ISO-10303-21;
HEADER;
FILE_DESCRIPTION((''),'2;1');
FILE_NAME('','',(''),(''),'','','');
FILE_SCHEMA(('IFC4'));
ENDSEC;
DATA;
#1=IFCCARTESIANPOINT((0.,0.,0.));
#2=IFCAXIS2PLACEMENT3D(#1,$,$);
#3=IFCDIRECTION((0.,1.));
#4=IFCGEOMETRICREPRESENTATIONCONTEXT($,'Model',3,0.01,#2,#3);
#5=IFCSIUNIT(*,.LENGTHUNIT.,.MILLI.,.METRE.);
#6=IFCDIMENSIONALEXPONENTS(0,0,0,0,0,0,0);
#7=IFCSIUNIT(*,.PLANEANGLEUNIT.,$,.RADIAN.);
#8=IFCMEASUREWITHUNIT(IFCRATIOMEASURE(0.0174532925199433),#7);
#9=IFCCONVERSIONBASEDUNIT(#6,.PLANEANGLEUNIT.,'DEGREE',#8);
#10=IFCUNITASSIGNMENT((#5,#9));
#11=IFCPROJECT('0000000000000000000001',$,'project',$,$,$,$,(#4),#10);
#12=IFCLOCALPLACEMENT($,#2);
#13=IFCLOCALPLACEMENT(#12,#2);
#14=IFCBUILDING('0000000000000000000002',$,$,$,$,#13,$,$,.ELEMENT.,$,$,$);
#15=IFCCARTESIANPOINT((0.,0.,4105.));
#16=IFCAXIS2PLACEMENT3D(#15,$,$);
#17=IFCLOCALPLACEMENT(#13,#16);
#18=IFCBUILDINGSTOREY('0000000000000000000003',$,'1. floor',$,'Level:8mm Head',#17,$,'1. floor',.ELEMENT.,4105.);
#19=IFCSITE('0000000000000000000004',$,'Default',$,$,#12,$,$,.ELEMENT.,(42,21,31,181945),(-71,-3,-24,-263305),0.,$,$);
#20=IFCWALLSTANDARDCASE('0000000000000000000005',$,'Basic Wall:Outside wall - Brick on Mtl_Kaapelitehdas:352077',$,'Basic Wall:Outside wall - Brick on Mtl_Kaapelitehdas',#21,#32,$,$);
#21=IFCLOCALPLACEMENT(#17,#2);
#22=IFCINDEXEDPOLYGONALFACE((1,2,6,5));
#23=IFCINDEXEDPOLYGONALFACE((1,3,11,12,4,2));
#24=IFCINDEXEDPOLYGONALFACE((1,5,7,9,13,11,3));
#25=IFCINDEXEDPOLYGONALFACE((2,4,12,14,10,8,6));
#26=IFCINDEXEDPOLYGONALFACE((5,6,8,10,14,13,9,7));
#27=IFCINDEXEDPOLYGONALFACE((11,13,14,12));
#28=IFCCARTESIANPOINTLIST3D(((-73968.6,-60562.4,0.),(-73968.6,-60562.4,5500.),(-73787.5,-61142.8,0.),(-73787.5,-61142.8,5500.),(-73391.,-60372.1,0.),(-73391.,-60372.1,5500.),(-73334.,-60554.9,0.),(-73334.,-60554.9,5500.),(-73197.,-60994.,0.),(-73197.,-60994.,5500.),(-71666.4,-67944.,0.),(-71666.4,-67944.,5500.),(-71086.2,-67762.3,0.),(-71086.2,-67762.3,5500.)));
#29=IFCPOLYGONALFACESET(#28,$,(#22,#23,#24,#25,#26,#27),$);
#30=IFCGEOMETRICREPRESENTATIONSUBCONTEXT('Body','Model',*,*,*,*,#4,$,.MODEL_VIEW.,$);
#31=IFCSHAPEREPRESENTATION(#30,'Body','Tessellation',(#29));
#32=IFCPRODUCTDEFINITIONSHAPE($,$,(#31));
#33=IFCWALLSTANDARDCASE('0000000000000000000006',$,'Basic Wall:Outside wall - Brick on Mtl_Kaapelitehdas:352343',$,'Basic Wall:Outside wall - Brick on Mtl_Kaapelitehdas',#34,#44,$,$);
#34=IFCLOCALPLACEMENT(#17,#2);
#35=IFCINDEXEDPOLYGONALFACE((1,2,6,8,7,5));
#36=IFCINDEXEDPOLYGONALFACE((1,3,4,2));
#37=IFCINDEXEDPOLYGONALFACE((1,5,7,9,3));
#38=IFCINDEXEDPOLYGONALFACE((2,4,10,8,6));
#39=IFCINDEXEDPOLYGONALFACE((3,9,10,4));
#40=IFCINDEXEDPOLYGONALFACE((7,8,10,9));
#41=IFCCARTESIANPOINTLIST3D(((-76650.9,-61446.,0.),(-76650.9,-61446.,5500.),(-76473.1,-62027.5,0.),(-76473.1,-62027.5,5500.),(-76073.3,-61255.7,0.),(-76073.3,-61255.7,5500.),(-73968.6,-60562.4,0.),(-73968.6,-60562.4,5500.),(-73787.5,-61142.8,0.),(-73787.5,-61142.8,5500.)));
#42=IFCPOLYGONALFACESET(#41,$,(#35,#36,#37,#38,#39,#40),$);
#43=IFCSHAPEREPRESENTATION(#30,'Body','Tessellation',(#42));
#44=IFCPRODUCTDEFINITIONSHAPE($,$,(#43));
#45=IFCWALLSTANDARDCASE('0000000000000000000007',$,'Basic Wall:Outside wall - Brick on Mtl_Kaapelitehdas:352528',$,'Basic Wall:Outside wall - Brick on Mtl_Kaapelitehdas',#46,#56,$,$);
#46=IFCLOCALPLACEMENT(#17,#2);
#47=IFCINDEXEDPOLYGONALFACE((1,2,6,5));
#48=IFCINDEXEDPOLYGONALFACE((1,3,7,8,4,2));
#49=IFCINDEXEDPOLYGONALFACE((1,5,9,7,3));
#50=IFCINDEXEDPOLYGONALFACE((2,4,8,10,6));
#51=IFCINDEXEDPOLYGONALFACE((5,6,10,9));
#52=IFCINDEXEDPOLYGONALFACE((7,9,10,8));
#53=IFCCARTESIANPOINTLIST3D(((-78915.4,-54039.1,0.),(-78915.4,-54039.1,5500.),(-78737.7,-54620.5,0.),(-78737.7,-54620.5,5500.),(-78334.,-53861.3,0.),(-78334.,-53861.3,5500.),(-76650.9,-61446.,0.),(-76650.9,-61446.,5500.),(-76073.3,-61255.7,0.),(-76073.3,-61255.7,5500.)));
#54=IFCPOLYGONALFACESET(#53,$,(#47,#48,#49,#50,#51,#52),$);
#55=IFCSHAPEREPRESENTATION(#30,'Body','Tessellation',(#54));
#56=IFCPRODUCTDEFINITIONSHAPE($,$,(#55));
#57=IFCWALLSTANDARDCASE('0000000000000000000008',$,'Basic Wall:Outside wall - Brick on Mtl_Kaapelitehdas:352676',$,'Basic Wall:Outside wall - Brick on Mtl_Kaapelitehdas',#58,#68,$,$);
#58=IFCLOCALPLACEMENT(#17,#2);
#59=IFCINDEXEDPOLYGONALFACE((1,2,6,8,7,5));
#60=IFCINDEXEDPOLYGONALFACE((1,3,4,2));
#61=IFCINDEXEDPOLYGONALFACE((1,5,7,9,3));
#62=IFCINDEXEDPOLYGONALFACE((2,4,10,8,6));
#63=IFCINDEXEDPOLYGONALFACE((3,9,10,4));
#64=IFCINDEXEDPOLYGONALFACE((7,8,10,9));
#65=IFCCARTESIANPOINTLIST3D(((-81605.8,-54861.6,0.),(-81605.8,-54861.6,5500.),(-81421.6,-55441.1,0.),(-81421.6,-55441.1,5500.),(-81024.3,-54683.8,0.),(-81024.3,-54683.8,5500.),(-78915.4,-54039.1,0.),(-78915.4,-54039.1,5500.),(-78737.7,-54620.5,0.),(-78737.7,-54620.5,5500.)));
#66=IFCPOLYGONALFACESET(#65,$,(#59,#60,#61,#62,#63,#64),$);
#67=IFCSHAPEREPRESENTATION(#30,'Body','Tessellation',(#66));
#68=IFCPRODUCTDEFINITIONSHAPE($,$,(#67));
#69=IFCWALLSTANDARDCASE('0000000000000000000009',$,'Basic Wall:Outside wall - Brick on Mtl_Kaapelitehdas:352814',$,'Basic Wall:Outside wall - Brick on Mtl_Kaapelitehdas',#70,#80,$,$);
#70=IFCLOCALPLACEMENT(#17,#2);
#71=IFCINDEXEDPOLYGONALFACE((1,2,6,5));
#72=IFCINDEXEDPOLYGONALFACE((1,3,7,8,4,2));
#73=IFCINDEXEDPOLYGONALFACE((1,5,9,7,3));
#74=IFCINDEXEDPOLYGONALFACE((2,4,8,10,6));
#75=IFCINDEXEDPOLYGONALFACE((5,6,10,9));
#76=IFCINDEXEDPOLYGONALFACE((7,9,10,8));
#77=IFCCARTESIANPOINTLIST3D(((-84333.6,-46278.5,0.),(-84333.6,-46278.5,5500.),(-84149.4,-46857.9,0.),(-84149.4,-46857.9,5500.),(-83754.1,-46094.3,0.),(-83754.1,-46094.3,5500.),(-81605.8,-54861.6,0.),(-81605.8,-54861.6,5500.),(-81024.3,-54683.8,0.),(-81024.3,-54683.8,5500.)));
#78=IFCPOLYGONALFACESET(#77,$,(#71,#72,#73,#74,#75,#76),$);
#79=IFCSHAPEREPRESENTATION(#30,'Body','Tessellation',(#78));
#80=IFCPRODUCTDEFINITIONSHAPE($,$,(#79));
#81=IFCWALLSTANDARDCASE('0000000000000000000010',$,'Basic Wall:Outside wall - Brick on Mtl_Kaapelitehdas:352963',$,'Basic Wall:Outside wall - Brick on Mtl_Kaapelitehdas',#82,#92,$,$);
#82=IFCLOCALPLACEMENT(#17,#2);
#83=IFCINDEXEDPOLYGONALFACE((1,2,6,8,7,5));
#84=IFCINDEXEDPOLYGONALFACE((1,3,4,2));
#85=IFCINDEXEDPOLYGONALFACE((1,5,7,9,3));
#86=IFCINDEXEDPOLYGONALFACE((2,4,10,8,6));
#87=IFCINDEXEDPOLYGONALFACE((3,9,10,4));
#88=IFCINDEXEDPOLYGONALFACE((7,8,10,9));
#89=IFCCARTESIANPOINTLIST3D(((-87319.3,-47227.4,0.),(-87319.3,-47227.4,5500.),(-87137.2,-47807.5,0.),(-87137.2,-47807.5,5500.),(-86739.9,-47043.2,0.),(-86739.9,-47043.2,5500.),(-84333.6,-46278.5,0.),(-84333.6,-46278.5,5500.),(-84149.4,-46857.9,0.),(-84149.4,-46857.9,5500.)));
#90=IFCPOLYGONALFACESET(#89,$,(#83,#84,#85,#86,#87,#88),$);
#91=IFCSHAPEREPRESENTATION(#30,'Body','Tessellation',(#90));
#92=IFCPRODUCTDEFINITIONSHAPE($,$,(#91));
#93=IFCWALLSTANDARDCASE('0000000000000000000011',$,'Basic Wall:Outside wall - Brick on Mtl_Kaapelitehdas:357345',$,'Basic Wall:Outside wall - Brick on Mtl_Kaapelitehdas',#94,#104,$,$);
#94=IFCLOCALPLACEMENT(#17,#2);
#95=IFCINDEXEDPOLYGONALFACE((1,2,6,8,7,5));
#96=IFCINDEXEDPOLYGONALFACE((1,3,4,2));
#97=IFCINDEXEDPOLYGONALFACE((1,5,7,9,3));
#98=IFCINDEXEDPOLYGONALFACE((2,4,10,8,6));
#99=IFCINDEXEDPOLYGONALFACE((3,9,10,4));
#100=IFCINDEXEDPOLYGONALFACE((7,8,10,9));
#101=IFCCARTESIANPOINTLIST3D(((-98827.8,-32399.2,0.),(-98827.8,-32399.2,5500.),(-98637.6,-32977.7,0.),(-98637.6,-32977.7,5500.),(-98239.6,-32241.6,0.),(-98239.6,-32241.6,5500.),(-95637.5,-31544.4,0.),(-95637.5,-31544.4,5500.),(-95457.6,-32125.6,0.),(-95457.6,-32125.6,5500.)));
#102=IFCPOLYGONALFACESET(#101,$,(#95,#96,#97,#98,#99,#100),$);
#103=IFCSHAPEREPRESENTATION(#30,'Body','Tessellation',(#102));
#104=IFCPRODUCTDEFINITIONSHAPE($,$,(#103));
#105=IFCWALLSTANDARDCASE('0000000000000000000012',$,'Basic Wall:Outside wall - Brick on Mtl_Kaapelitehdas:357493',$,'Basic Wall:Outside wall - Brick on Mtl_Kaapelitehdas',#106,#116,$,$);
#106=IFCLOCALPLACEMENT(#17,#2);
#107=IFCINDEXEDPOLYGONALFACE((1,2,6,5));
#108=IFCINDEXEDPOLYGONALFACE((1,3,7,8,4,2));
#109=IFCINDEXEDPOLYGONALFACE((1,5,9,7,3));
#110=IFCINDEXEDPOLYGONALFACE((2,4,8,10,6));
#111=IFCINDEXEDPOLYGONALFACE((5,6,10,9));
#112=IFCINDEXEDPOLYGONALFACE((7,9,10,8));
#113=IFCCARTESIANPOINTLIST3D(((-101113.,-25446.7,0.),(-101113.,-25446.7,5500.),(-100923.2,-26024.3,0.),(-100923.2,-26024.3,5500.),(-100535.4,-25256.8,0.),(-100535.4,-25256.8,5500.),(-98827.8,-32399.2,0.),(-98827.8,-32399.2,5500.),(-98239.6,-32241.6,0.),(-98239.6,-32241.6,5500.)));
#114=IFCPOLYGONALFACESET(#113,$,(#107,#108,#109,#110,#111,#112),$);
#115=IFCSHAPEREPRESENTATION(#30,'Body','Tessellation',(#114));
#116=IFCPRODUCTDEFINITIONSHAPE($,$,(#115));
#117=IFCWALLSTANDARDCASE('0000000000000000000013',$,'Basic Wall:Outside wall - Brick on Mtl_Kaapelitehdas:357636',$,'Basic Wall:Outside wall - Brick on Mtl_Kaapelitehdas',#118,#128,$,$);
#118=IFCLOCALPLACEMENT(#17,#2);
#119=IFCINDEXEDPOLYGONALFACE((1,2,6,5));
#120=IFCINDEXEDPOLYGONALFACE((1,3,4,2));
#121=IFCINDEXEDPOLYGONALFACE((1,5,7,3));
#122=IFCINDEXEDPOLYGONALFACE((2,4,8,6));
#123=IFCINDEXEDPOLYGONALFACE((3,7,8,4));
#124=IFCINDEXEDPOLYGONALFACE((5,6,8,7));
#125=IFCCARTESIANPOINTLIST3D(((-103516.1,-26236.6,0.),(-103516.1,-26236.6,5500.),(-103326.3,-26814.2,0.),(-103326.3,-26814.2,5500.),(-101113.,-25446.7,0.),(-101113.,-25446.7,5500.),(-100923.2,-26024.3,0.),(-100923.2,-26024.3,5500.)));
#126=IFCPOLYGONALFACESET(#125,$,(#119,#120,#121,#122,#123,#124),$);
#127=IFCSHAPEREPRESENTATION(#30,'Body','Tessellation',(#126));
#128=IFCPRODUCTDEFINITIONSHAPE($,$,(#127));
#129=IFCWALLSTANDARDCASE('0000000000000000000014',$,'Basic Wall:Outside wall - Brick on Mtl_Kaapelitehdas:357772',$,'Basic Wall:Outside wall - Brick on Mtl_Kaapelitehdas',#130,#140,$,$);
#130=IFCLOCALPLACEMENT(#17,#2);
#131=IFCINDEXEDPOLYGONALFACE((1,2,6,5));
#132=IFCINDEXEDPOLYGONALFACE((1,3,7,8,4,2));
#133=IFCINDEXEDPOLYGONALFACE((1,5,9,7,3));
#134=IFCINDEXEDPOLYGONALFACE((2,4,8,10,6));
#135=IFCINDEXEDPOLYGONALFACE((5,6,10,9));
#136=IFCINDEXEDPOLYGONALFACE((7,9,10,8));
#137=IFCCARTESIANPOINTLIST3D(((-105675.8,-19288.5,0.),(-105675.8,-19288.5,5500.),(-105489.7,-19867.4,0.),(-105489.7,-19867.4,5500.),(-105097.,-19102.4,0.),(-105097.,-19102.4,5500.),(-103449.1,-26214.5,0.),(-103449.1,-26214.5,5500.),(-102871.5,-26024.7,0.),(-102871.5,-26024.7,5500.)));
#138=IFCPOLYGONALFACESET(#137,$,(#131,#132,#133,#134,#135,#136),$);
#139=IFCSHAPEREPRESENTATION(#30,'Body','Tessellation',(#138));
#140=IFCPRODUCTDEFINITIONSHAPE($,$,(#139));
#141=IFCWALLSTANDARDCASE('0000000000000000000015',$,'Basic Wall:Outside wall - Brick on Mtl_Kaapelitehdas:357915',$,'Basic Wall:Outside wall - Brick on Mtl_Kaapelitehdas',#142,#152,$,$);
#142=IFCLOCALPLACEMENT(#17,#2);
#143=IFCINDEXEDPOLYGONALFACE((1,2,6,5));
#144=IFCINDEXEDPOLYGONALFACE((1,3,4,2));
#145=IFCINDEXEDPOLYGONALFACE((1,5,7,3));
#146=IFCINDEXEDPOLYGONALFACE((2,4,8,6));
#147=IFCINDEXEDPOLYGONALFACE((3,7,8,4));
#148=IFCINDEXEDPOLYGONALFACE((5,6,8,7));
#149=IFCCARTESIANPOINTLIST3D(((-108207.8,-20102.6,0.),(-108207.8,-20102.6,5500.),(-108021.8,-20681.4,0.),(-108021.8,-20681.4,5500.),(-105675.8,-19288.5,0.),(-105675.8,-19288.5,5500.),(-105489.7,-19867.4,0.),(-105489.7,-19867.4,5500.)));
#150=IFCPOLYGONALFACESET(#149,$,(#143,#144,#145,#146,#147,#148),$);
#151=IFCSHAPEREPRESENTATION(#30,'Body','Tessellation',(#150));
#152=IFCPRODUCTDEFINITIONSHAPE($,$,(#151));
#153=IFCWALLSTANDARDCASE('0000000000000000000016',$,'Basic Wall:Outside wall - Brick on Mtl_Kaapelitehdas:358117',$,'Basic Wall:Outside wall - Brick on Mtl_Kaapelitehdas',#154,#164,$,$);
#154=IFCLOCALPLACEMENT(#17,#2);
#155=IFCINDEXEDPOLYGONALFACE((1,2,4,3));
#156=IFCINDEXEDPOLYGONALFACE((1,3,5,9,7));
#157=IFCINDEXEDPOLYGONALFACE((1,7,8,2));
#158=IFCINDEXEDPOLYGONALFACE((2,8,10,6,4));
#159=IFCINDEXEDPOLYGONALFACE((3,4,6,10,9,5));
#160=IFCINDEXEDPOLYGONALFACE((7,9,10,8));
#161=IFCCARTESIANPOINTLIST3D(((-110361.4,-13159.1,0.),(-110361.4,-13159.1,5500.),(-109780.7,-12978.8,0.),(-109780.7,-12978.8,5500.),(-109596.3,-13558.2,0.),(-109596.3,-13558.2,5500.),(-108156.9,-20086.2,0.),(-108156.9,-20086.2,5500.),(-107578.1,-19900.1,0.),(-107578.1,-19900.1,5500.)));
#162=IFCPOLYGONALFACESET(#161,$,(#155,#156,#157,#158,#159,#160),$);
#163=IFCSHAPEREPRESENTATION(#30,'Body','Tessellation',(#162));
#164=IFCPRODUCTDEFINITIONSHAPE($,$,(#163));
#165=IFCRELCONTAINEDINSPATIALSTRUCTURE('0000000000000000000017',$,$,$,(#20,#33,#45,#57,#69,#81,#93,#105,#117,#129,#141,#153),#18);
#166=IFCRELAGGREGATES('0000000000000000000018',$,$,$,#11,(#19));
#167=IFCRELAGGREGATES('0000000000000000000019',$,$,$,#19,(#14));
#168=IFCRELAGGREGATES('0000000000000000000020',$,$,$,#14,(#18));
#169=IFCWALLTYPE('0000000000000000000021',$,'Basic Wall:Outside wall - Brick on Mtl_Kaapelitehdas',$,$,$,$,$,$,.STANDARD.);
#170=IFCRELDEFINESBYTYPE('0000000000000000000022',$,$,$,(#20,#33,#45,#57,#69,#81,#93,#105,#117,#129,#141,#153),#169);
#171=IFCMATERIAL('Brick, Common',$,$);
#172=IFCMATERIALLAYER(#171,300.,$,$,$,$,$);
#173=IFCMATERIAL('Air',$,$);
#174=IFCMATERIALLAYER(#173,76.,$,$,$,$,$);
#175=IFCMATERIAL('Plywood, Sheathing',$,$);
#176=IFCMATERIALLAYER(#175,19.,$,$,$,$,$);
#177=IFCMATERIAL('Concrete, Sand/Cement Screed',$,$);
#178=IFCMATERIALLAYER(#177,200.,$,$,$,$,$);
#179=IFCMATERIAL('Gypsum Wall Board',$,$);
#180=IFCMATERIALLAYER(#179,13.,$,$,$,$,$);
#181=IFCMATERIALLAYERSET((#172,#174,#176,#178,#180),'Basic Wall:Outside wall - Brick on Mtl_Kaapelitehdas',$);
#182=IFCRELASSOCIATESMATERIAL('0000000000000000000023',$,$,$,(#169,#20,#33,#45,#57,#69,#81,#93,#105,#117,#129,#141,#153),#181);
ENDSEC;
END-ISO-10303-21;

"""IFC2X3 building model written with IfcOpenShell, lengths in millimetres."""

from ifc_helpers import new_model, entity, si_unit, converted_unit, direction, frame, frame_2d, origin, place, context, subcontext, project, spatial, polyline, rectangle, outline, extrude, material, layer, layer_set, layer_usage, type_object, element, save


model = new_model("IFC2X3")

# Units and contexts
model_context = context("Model", 3, precision=0.01, world=origin(), true_north=direction((0.0, 1.0)))
body_context = subcontext(model_context, "Body", "Model", "MODEL_VIEW")
ifc_project = project(units=[si_unit("LENGTHUNIT", "METRE", prefix="MILLI"), converted_unit("PLANEANGLEUNIT", "DEGREE", entity("IfcRatioMeasure", 0.0174532925199433), si_unit("PLANEANGLEUNIT", "RADIAN"), dimensions=[0, 0, 0, 0, 0, 0, 0])], contexts=[model_context])

# Site, building, storey
site_placement = place(None, origin())
site = spatial("IfcSite", under=ifc_project, at=site_placement, Name="Default", CompositionType="ELEMENT", RefLatitude=(42, 21, 31, 181945), RefLongitude=(-71, -3, -24, -263305), RefElevation=0.0)
building_placement = place(site_placement, origin())
building = spatial("IfcBuilding", under=site, at=building_placement, CompositionType="ELEMENT")
storey_placement = place(building_placement, frame((0.0, 0.0, 4105.0)))
storey = spatial("IfcBuildingStorey", under=building, at=storey_placement, Name="1. floor", ObjectType="Level:8mm Head", LongName="1. floor", CompositionType="ELEMENT", Elevation=4105.0)

# Walls
ifc_material_1 = material(Name="Brick, Common")
ifc_layer_1 = layer(ifc_material_1, 300.0)
ifc_material_2 = material(Name="Air")
ifc_layer_2 = layer(ifc_material_2, 76.0)
ifc_material_3 = material(Name="Plywood, Sheathing")
ifc_layer_3 = layer(ifc_material_3, 19.0)
ifc_material_4 = material(Name="Concrete, Sand/Cement Screed")
ifc_layer_4 = layer(ifc_material_4, 200.0)
ifc_material_5 = material(Name="Gypsum Wall Board")
ifc_layer_5 = layer(ifc_material_5, 13.0)
ifc_layer_set_1 = layer_set([ifc_layer_1, ifc_layer_2, ifc_layer_3, ifc_layer_4, ifc_layer_5], Name="Basic Wall:Outside wall - Brick on Mtl_Kaapelitehdas")
ifc_layer_usage_1 = layer_usage(ifc_layer_set_1, "AXIS2", "NEGATIVE", 304.0)
wall_type_1 = type_object("IfcWallType", Name="Basic Wall:Outside wall - Brick on Mtl_Kaapelitehdas", PredefinedType="STANDARD", material=ifc_layer_set_1)
wall_1_placement = place(storey_placement, frame((-71376.1, -67853.5, 0.0), z_axis=(0.0, 0.0, 1.0), x_axis=(-0.297735, 0.954648, 0.0)))
element("IfcWallStandardCase", 1, at=wall_1_placement, inside=storey, type_object=wall_type_1, material=ifc_layer_usage_1, Name="Basic Wall:Outside wall - Brick on Mtl_Kaapelitehdas:352077", ObjectType="Basic Wall:Outside wall - Brick on Mtl_Kaapelitehdas", context=body_context, shape_type="SweptSolid", body=[
    extrude(outline(polyline([(7742.0, -304.0), (7732.3, 304.0), (7124.3, 304.0), (0.0, 304.0), (0.8, -304.0), (7090.5, -304.0), (7550.5, -304.0), (7742.0, -304.0)])), origin(), (0.0, 0.0, 1.0), 5500.0),
])
ifc_layer_usage_2 = layer_usage(ifc_layer_set_1, "AXIS2", "NEGATIVE", 304.0)
wall_2_placement = place(storey_placement, frame((-73873.4, -60851.1, 0.0), z_axis=(0.0, 0.0, 1.0), x_axis=(-0.949794, -0.312877, 0.0)))
element("IfcWallStandardCase", 2, at=wall_2_placement, inside=storey, type_object=wall_type_1, material=ifc_layer_usage_2, Name="Basic Wall:Outside wall - Brick on Mtl_Kaapelitehdas:352343", ObjectType="Basic Wall:Outside wall - Brick on Mtl_Kaapelitehdas", context=body_context, shape_type="SweptSolid", body=[
    extrude(outline(polyline([(2824.1, -304.0), (2837.2, 304.0), (9.7, 304.0), (0.0, -304.0), (2216.0, -304.0), (2824.1, -304.0)])), origin(), (0.0, 0.0, 1.0), 5500.0),
])
ifc_layer_usage_3 = layer_usage(ifc_layer_set_1, "AXIS2", "NEGATIVE", 304.0)
wall_3_placement = place(storey_placement, frame((-76360.2, -61357.1, 0.0), z_axis=(0.0, 0.0, 1.0), x_axis=(-0.292372, 0.956305, 0.0)))
element("IfcWallStandardCase", 3, at=wall_3_placement, inside=storey, type_object=wall_type_1, material=ifc_layer_usage_3, Name="Basic Wall:Outside wall - Brick on Mtl_Kaapelitehdas:352528", ObjectType="Basic Wall:Outside wall - Brick on Mtl_Kaapelitehdas", context=body_context, shape_type="SweptSolid", body=[
    extrude(outline(polyline([(7745.3, -304.0), (7745.3, 304.0), (7137.3, 304.0), (0.0, 304.0), (13.1, -304.0), (7745.3, -304.0)])), origin(), (0.0, 0.0, 1.0), 5500.0),
])
ifc_layer_usage_4 = layer_usage(ifc_layer_set_1, "AXIS2", "NEGATIVE", 304.0)
wall_4_placement = place(storey_placement, frame((-78826.5, -54329.8, 0.0), z_axis=(0.0, 0.0, 1.0), x_axis=(-0.956305, -0.292372, 0.0)))
element("IfcWallStandardCase", 4, at=wall_4_placement, inside=storey, type_object=wall_type_1, material=ifc_layer_usage_4, Name="Basic Wall:Outside wall - Brick on Mtl_Kaapelitehdas:352676", ObjectType="Basic Wall:Outside wall - Brick on Mtl_Kaapelitehdas", context=body_context, shape_type="SweptSolid", body=[
    extrude(outline(polyline([(2813.3, -304.0), (2806.6, 304.0), (0.0, 304.0), (0.0, -304.0), (2205.2, -304.0), (2813.3, -304.0)])), origin(), (0.0, 0.0, 1.0), 5500.0),
])
ifc_layer_usage_5 = layer_usage(ifc_layer_set_1, "AXIS2", "NEGATIVE", 304.0)
wall_5_placement = place(storey_placement, frame((-81314.0, -54775.9, 0.0), z_axis=(0.0, 0.0, 1.0), x_axis=(-0.302882, 0.953028, 0.0)))
element("IfcWallStandardCase", 5, at=wall_5_placement, inside=storey, type_object=wall_type_1, material=ifc_layer_usage_5, Name="Basic Wall:Outside wall - Brick on Mtl_Kaapelitehdas:352814", ObjectType="Basic Wall:Outside wall - Brick on Mtl_Kaapelitehdas", context=body_context, shape_type="SweptSolid", body=[
    extrude(outline(polyline([(9012.8, -304.0), (9012.8, 304.0), (8404.8, 304.0), (6.7, 304.0), (0.0, -304.0), (9012.8, -304.0)])), origin(), (0.0, 0.0, 1.0), 5500.0),
])
ifc_layer_usage_6 = layer_usage(ifc_layer_set_1, "AXIS2", "NEGATIVE", 304.0)
wall_6_placement = place(storey_placement, frame((-84241.5, -46568.2, 0.0), z_axis=(0.0, 0.0, 1.0), x_axis=(-0.953028, -0.302882, 0.0)))
element("IfcWallStandardCase", 6, at=wall_6_placement, inside=storey, type_object=wall_type_1, material=ifc_layer_usage_6, Name="Basic Wall:Outside wall - Brick on Mtl_Kaapelitehdas:352963", ObjectType="Basic Wall:Outside wall - Brick on Mtl_Kaapelitehdas", context=body_context, shape_type="SweptSolid", body=[
    extrude(outline(polyline([(3132.9, -304.0), (3135.1, 304.0), (0.0, 304.0), (0.0, -304.0), (2524.9, -304.0), (3132.9, -304.0)])), origin(), (0.0, 0.0, 1.0), 5500.0),
])
ifc_layer_usage_7 = layer_usage(ifc_layer_set_1, "AXIS2", "NEGATIVE", 304.0)
wall_7_placement = place(storey_placement, frame((-95536.3, -31832.0, 0.0), z_axis=(0.0, 0.0, 1.0), x_axis=(-0.965926, -0.258819, 0.0)))
element("IfcWallStandardCase", 7, at=wall_7_placement, inside=storey, type_object=wall_type_1, material=ifc_layer_usage_7, Name="Basic Wall:Outside wall - Brick on Mtl_Kaapelitehdas:357345", ObjectType="Basic Wall:Outside wall - Brick on Mtl_Kaapelitehdas", context=body_context, shape_type="SweptSolid", body=[
    extrude(outline(polyline([(3326.1, -304.0), (3292.2, 304.0), (0.0, 304.0), (23.3, -304.0), (2717.2, -304.0), (3326.1, -304.0)])), origin(), (0.0, 0.0, 1.0), 5500.0),
])
ifc_layer_usage_8 = layer_usage(ifc_layer_set_1, "AXIS2", "NEGATIVE", 304.0)
wall_8_placement = place(storey_placement, frame((-98528.4, -32336.5, 0.0), z_axis=(0.0, 0.0, 1.0), x_axis=(-0.312256, 0.949998, 0.0)))
element("IfcWallStandardCase", 8, at=wall_8_placement, inside=storey, type_object=wall_type_1, material=ifc_layer_usage_8, Name="Basic Wall:Outside wall - Brick on Mtl_Kaapelitehdas:357493", ObjectType="Basic Wall:Outside wall - Brick on Mtl_Kaapelitehdas", context=body_context, shape_type="SweptSolid", body=[
    extrude(outline(polyline([(7352.4, -304.0), (7352.4, 304.0), (6744.4, 304.0), (33.9, 304.0), (0.0, -304.0), (7352.4, -304.0)])), origin(), (0.0, 0.0, 1.0), 5500.0),
])
ifc_layer_usage_9 = layer_usage(ifc_layer_set_1, "AXIS2", "NEGATIVE", 304.0)
wall_9_placement = place(storey_placement, frame((-101018.1, -25735.5, 0.0), z_axis=(0.0, 0.0, 1.0), x_axis=(-0.949998, -0.312256, 0.0)))
element("IfcWallStandardCase", 9, at=wall_9_placement, inside=storey, type_object=wall_type_1, material=ifc_layer_usage_9, Name="Basic Wall:Outside wall - Brick on Mtl_Kaapelitehdas:357636", ObjectType="Basic Wall:Outside wall - Brick on Mtl_Kaapelitehdas", context=body_context, shape_type="SweptSolid", body=[
    extrude(rectangle(XDim=2529.6, YDim=608.0, at=frame_2d((1264.8, 0.0), x_axis=(-1.0, 0.0))), origin(), (0.0, 0.0, 1.0), 5500.0),
])
ifc_layer_usage_10 = layer_usage(ifc_layer_set_1, "AXIS2", "NEGATIVE", 304.0)
wall_10_placement = place(storey_placement, frame((-103159.7, -26121.5, 0.0), z_axis=(0.0, 0.0, 1.0), x_axis=(-0.306077, 0.952007, 0.0)))
element("IfcWallStandardCase", 10, at=wall_10_placement, inside=storey, type_object=wall_type_1, material=ifc_layer_usage_10, Name="Basic Wall:Outside wall - Brick on Mtl_Kaapelitehdas:357772", ObjectType="Basic Wall:Outside wall - Brick on Mtl_Kaapelitehdas", context=body_context, shape_type="SweptSolid", body=[
    extrude(outline(polyline([(7275.1, -304.0), (7275.1, 304.0), (6667.1, 304.0), (0.0, 304.0), (4.0, -304.0), (7275.1, -304.0)])), origin(), (0.0, 0.0, 1.0), 5500.0),
])
ifc_layer_usage_11 = layer_usage(ifc_layer_set_1, "AXIS2", "NEGATIVE", 304.0)
wall_11_placement = place(storey_placement, frame((-105582.8, -19577.9, 0.0), z_axis=(0.0, 0.0, 1.0), x_axis=(-0.952007, -0.306077, 0.0)))
element("IfcWallStandardCase", 11, at=wall_11_placement, inside=storey, type_object=wall_type_1, material=ifc_layer_usage_11, Name="Basic Wall:Outside wall - Brick on Mtl_Kaapelitehdas:357915", ObjectType="Basic Wall:Outside wall - Brick on Mtl_Kaapelitehdas", context=body_context, shape_type="SweptSolid", body=[
    extrude(rectangle(XDim=2659.7, YDim=608.0, at=frame_2d((1329.8, 0.0), x_axis=(-1.0, 0.0))), origin(), (0.0, 0.0, 1.0), 5500.0),
])
ifc_layer_usage_12 = layer_usage(ifc_layer_set_1, "AXIS2", "NEGATIVE", 304.0)
wall_12_placement = place(storey_placement, frame((-107867.2, -19994.0, 0.0), z_axis=(0.0, 0.0, 1.0), x_axis=(-0.303248, 0.952912, 0.0)))
element("IfcWallStandardCase", 12, at=wall_12_placement, inside=storey, type_object=wall_type_1, material=ifc_layer_usage_12, Name="Basic Wall:Outside wall - Brick on Mtl_Kaapelitehdas:358117", ObjectType="Basic Wall:Outside wall - Brick on Mtl_Kaapelitehdas", context=body_context, shape_type="SweptSolid", body=[
    extrude(outline(polyline([(7265.1, -304.0), (7269.5, 304.0), (0.0, 304.0), (1.8, -304.0), (6657.1, -304.0), (7265.1, -304.0)])), origin(), (0.0, 0.0, 1.0), 5500.0),
])

save(model, "model.ifc")
